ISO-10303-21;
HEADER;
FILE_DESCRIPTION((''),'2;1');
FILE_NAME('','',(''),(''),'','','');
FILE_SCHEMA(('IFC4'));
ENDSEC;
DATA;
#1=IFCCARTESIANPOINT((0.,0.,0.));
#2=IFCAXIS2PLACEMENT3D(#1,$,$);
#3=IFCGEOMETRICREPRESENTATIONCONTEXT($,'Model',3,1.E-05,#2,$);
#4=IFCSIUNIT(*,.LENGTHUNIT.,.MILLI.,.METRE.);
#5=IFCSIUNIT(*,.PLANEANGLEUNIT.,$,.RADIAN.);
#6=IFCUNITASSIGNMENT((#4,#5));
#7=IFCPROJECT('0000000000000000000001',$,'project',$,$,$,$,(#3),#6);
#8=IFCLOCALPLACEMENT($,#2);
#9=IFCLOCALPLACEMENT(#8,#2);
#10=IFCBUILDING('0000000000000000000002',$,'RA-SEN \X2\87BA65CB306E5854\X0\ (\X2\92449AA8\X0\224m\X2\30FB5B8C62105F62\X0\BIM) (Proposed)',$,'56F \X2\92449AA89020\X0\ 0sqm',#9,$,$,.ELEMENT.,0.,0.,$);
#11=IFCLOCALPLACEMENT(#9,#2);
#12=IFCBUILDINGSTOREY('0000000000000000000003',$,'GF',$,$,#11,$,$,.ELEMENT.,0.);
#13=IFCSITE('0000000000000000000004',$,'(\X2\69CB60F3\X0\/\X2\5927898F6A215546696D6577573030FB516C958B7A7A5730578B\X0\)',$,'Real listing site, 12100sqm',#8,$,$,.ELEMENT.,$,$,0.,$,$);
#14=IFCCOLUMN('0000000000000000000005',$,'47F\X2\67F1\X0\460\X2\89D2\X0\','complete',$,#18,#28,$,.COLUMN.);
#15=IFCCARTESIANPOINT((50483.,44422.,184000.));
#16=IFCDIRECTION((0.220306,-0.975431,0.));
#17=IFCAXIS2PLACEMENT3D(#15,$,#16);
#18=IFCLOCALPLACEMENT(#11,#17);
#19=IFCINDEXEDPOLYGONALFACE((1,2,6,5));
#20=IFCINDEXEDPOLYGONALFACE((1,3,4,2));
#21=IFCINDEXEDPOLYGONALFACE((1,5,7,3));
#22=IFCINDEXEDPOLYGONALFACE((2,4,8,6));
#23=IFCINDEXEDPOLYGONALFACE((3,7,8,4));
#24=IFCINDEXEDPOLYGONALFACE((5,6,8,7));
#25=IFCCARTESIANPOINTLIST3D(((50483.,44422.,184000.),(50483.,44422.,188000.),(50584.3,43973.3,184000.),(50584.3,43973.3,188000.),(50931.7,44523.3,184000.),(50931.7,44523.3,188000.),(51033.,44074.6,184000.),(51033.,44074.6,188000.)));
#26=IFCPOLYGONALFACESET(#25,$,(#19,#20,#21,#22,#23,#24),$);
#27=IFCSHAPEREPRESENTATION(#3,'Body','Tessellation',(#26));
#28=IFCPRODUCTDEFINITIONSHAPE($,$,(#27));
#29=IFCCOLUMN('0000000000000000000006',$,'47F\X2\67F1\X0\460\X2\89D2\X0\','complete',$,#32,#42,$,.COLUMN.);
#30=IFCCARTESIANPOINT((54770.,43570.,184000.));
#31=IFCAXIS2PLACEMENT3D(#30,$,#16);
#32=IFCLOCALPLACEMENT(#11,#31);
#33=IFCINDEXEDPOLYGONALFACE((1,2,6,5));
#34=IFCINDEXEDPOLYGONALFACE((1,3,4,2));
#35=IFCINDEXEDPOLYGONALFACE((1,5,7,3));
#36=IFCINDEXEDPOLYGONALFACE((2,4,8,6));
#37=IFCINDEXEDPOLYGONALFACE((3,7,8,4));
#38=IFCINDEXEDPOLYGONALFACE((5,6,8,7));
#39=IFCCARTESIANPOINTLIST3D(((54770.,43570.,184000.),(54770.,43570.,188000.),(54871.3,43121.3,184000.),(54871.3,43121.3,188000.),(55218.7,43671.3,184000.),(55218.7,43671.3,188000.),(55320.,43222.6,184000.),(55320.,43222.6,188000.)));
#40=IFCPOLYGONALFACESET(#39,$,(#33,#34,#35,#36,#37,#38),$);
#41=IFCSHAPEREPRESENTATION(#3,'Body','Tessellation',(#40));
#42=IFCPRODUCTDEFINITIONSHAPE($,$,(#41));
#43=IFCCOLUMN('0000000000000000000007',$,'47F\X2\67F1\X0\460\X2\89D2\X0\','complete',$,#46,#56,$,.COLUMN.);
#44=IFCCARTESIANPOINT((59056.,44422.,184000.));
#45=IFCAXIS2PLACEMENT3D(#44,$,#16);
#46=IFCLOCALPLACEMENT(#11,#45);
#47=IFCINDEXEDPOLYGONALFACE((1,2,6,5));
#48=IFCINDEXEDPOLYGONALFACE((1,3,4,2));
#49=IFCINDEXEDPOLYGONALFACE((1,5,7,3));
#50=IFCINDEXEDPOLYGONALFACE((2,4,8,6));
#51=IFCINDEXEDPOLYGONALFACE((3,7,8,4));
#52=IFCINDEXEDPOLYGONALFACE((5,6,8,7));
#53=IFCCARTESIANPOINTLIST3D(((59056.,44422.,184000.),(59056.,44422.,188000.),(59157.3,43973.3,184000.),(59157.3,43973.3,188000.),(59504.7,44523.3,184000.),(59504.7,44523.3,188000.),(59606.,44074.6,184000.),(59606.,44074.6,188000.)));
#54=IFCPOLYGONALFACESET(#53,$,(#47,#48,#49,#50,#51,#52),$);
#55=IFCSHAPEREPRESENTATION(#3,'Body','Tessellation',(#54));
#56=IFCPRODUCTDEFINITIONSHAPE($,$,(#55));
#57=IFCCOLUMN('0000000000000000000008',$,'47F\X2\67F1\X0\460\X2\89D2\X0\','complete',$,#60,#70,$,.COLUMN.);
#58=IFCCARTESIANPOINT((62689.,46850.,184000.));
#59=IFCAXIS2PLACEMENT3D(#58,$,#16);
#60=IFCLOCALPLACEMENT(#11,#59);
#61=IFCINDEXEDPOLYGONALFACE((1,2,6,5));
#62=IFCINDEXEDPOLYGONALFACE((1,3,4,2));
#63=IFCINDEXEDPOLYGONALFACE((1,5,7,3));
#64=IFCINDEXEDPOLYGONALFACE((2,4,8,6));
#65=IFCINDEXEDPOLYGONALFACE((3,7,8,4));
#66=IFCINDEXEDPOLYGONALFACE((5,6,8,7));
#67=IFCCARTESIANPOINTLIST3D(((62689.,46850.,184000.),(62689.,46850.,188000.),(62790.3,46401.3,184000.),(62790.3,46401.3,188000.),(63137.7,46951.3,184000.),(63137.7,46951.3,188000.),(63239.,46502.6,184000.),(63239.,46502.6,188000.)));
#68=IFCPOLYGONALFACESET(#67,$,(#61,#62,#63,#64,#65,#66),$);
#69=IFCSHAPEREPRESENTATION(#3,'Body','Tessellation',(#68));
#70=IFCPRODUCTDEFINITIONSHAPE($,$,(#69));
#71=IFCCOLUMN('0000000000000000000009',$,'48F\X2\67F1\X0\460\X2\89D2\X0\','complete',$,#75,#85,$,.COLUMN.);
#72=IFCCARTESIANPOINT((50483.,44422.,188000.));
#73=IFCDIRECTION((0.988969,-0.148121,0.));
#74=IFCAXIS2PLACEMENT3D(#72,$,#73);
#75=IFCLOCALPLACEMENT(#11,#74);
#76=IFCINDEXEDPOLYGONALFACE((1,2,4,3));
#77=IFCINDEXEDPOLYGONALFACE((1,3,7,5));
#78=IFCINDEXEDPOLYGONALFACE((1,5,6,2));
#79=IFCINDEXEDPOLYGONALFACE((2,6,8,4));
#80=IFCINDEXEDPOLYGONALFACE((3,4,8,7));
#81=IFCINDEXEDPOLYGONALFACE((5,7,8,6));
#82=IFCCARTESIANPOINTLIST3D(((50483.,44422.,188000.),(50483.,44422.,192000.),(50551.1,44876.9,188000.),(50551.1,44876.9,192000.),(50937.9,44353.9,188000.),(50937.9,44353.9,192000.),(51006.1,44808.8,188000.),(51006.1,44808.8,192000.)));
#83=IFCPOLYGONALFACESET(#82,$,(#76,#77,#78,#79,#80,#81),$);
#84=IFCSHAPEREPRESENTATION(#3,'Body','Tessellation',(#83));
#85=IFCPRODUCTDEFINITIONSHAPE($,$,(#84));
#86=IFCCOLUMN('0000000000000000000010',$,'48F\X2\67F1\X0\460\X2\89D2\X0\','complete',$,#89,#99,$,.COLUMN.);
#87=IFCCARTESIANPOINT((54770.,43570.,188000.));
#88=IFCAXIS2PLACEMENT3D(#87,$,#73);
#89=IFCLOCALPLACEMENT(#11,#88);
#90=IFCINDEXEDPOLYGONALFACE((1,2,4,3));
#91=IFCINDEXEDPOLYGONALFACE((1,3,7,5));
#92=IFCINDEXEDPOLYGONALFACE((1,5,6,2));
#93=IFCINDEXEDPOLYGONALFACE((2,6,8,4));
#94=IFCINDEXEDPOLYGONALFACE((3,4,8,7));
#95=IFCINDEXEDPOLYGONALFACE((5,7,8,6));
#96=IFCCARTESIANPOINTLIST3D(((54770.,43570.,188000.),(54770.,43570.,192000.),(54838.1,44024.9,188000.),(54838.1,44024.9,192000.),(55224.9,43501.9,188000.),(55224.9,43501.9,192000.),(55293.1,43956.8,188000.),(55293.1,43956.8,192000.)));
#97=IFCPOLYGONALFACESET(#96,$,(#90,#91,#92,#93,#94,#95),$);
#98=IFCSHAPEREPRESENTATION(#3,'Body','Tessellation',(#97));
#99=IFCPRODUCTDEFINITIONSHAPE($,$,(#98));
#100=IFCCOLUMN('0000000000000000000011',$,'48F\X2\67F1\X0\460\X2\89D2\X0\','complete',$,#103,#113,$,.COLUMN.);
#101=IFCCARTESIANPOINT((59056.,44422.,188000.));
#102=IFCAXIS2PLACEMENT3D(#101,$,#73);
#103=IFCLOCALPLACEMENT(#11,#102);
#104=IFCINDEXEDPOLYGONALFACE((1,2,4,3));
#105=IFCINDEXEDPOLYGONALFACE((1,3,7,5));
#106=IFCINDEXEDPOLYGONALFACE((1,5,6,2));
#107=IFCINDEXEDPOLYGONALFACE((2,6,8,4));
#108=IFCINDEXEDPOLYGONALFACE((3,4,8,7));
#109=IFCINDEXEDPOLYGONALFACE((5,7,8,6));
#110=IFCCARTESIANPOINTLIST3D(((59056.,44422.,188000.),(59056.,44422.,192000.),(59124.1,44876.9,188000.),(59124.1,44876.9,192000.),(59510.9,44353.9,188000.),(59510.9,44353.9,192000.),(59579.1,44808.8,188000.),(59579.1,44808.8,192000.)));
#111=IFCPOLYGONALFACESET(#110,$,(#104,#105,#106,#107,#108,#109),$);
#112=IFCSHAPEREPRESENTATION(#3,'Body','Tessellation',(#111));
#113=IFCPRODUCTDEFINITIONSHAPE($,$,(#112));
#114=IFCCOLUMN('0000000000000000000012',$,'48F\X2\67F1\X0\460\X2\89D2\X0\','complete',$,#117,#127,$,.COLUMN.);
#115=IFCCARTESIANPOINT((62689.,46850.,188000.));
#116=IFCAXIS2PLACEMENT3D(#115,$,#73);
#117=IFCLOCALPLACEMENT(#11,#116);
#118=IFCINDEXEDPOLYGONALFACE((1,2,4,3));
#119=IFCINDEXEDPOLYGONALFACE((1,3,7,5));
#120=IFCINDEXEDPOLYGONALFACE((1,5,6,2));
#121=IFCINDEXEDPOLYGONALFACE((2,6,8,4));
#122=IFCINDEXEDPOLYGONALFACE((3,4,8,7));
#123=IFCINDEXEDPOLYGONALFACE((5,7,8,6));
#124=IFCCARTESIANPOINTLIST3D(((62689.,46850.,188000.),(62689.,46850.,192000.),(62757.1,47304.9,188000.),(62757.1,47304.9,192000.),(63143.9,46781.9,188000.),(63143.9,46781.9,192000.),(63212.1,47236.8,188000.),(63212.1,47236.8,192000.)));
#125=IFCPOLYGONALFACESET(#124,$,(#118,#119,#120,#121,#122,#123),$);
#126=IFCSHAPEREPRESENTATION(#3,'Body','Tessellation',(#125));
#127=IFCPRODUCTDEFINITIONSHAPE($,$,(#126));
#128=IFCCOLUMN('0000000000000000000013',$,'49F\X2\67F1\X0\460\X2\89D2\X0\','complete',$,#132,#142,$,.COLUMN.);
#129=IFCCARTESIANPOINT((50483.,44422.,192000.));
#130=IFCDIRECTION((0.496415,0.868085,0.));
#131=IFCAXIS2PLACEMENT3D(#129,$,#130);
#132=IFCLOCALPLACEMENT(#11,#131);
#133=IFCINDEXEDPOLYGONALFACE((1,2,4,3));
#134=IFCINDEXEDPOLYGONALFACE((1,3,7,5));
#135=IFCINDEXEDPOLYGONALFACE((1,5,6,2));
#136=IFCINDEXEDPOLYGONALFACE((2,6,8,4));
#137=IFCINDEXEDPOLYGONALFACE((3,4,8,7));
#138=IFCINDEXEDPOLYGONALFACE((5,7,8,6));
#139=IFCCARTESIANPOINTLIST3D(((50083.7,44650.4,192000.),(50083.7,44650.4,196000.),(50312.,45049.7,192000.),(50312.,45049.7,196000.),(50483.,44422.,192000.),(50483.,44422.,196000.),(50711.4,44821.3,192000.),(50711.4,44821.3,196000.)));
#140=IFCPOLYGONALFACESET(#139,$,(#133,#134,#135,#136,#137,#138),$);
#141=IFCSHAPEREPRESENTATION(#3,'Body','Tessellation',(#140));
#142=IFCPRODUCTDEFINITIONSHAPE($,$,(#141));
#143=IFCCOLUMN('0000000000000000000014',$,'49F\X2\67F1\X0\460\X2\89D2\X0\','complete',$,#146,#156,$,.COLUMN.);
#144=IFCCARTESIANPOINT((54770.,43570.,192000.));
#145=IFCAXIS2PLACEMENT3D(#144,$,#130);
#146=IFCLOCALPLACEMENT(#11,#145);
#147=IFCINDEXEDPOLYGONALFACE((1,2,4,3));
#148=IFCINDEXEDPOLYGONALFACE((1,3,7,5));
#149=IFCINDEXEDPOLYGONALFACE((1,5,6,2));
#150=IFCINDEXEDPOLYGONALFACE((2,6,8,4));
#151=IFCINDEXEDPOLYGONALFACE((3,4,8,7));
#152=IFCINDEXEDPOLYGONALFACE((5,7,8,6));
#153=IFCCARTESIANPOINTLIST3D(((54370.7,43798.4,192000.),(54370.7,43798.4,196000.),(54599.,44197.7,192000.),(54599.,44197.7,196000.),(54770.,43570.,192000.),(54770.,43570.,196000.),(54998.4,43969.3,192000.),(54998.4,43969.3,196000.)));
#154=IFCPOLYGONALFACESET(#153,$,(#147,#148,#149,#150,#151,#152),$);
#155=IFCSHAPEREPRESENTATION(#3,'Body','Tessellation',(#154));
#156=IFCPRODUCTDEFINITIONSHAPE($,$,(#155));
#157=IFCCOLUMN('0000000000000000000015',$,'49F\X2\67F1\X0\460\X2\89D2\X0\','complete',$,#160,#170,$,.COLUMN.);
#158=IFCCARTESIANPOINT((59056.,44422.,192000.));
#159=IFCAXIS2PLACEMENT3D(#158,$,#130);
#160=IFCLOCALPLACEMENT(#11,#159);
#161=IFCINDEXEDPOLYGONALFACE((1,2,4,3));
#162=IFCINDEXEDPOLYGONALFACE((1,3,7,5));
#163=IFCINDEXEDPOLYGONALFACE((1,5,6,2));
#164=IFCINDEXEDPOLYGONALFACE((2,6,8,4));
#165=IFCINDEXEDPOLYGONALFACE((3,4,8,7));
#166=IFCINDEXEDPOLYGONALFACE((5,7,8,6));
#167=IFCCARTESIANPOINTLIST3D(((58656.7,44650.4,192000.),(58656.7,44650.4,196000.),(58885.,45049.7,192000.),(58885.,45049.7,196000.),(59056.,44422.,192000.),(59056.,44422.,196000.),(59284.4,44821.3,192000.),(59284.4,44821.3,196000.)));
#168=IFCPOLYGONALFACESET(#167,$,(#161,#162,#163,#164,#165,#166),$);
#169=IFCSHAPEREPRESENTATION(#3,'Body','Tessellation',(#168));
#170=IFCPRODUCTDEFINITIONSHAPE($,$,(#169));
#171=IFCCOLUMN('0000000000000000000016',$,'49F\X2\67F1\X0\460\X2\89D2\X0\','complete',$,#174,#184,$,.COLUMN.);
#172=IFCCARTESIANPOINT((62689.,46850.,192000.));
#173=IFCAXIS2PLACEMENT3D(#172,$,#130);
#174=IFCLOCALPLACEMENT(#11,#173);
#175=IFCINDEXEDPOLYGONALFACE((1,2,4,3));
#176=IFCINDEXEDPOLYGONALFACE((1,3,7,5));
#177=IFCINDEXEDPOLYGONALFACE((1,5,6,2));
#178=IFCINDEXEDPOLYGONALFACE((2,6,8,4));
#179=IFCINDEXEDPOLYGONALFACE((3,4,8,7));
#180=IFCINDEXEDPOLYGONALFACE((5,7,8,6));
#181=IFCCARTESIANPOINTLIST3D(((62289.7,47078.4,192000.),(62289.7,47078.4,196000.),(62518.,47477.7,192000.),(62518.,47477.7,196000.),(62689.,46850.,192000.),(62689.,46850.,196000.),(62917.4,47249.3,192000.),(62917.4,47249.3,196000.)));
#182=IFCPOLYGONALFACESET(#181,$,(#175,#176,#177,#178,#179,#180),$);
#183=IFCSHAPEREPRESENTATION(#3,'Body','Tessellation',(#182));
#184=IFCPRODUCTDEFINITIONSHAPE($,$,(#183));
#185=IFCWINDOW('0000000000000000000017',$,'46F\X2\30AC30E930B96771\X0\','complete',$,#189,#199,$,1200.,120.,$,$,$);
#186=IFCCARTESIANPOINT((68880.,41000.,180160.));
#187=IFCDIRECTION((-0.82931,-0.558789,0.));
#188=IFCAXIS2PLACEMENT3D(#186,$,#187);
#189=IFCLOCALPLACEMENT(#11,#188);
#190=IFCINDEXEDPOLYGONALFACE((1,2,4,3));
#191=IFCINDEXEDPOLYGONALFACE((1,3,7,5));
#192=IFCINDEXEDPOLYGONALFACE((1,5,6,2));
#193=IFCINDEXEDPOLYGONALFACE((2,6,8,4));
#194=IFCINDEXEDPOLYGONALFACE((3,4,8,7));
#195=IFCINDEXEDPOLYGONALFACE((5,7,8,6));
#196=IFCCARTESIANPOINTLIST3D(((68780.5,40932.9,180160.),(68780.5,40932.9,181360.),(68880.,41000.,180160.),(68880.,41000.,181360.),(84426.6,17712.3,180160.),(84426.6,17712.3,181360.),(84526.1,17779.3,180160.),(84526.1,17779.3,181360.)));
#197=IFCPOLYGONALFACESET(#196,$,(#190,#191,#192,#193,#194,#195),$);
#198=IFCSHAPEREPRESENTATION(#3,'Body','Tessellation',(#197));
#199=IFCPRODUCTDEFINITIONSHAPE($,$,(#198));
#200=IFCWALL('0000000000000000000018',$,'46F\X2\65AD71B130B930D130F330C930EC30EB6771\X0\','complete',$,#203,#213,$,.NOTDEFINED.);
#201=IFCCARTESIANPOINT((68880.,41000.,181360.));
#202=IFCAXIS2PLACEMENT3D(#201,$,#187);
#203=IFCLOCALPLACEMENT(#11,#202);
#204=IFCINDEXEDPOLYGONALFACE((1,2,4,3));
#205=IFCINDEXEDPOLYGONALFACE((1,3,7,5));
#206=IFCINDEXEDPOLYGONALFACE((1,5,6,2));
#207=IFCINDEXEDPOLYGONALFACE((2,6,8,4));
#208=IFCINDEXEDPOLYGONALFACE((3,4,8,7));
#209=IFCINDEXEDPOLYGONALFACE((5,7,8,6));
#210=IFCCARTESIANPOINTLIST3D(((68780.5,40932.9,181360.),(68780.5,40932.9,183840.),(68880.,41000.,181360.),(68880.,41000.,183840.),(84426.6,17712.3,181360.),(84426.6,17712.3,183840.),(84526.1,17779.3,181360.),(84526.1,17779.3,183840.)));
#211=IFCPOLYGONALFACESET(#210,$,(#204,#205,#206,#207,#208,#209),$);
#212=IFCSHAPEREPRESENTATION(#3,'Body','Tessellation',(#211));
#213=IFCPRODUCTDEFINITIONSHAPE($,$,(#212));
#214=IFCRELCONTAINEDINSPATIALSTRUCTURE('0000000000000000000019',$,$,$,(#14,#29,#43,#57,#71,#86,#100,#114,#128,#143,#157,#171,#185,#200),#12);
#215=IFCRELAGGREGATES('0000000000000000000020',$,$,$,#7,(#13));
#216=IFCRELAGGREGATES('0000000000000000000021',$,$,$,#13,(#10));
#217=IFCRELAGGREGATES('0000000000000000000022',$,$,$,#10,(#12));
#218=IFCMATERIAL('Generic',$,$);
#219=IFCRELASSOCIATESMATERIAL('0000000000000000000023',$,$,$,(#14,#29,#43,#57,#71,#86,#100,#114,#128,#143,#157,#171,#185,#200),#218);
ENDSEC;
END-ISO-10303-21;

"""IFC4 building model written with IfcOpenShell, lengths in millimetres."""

from ifc_helpers import new_model, si_unit, frame, frame_2d, origin, place, context, project, spatial, rectangle, extrude, material, element, save


model = new_model("IFC4")

# Units and contexts
model_context = context("Model", 3, precision=1e-05, world=origin())
ifc_project = project(units=[si_unit("LENGTHUNIT", "METRE", prefix="MILLI"), si_unit("PLANEANGLEUNIT", "RADIAN")], contexts=[model_context])

# Site, building, storey
site_placement = place(None, origin())
site = spatial("IfcSite", under=ifc_project, at=site_placement, Name="(構想/大規模商業敷地・公開空地型)", ObjectType="Real listing site, 12100sqm", CompositionType="ELEMENT", RefElevation=0.0)
building_placement = place(site_placement, origin())
building = spatial("IfcBuilding", under=site, at=building_placement, Name="RA-SEN 螺旋の塔 (鉄骨224m・完成形BIM) (Proposed)", ObjectType="56F 鉄骨造 0sqm", CompositionType="ELEMENT", ElevationOfRefHeight=0.0, ElevationOfTerrain=0.0)
storey_placement = place(building_placement, origin())
storey = spatial("IfcBuildingStorey", under=building, at=storey_placement, Name="GF", CompositionType="ELEMENT", Elevation=0.0)

# Columns
ifc_material = material(Name="Generic")
column_1_placement = place(storey_placement, frame((50483.0, 44422.0, 184000.0), x_axis=(0.220306, -0.975431, 0.0)))
element("IfcColumn", 1, at=column_1_placement, inside=storey, material=ifc_material, Name="47F柱460角", Description="complete", PredefinedType="COLUMN", context=model_context, shape_type="SweptSolid", body=[
    extrude(rectangle(XDim=460.0, YDim=460.0, at=frame_2d((230.0, 230.0))), frame((50483.0, 44422.0, 184000.0), x_axis=(0.220306, -0.975431, 0.0)), (0.0, 0.0, 1.0), 4000.0),
])
column_2_placement = place(storey_placement, frame((54770.0, 43570.0, 184000.0), x_axis=(0.220306, -0.975431, 0.0)))
element("IfcColumn", 2, at=column_2_placement, inside=storey, material=ifc_material, Name="47F柱460角", Description="complete", PredefinedType="COLUMN", context=model_context, shape_type="SweptSolid", body=[
    extrude(rectangle(XDim=460.0, YDim=460.0, at=frame_2d((230.0, 230.0))), frame((54770.0, 43570.0, 184000.0), x_axis=(0.220306, -0.975431, 0.0)), (0.0, 0.0, 1.0), 4000.0),
])
column_3_placement = place(storey_placement, frame((59056.0, 44422.0, 184000.0), x_axis=(0.220306, -0.975431, 0.0)))
element("IfcColumn", 3, at=column_3_placement, inside=storey, material=ifc_material, Name="47F柱460角", Description="complete", PredefinedType="COLUMN", context=model_context, shape_type="SweptSolid", body=[
    extrude(rectangle(XDim=460.0, YDim=460.0, at=frame_2d((230.0, 230.0))), frame((59056.0, 44422.0, 184000.0), x_axis=(0.220306, -0.975431, 0.0)), (0.0, 0.0, 1.0), 4000.0),
])
column_4_placement = place(storey_placement, frame((62689.0, 46850.0, 184000.0), x_axis=(0.220306, -0.975431, 0.0)))
element("IfcColumn", 4, at=column_4_placement, inside=storey, material=ifc_material, Name="47F柱460角", Description="complete", PredefinedType="COLUMN", context=model_context, shape_type="SweptSolid", body=[
    extrude(rectangle(XDim=460.0, YDim=460.0, at=frame_2d((230.0, 230.0))), frame((62689.0, 46850.0, 184000.0), x_axis=(0.220306, -0.975431, 0.0)), (0.0, 0.0, 1.0), 4000.0),
])
column_5_placement = place(storey_placement, frame((50483.0, 44422.0, 188000.0), x_axis=(0.988969, -0.148121, 0.0)))
element("IfcColumn", 5, at=column_5_placement, inside=storey, material=ifc_material, Name="48F柱460角", Description="complete", PredefinedType="COLUMN", context=model_context, shape_type="SweptSolid", body=[
    extrude(rectangle(XDim=460.0, YDim=460.0, at=frame_2d((230.0, 230.0))), frame((50483.0, 44422.0, 188000.0), x_axis=(0.988969, -0.148121, 0.0)), (0.0, 0.0, 1.0), 4000.0),
])
column_6_placement = place(storey_placement, frame((54770.0, 43570.0, 188000.0), x_axis=(0.988969, -0.148121, 0.0)))
element("IfcColumn", 6, at=column_6_placement, inside=storey, material=ifc_material, Name="48F柱460角", Description="complete", PredefinedType="COLUMN", context=model_context, shape_type="SweptSolid", body=[
    extrude(rectangle(XDim=460.0, YDim=460.0, at=frame_2d((230.0, 230.0))), frame((54770.0, 43570.0, 188000.0), x_axis=(0.988969, -0.148121, 0.0)), (0.0, 0.0, 1.0), 4000.0),
])
column_7_placement = place(storey_placement, frame((59056.0, 44422.0, 188000.0), x_axis=(0.988969, -0.148121, 0.0)))
element("IfcColumn", 7, at=column_7_placement, inside=storey, material=ifc_material, Name="48F柱460角", Description="complete", PredefinedType="COLUMN", context=model_context, shape_type="SweptSolid", body=[
    extrude(rectangle(XDim=460.0, YDim=460.0, at=frame_2d((230.0, 230.0))), frame((59056.0, 44422.0, 188000.0), x_axis=(0.988969, -0.148121, 0.0)), (0.0, 0.0, 1.0), 4000.0),
])
column_8_placement = place(storey_placement, frame((62689.0, 46850.0, 188000.0), x_axis=(0.988969, -0.148121, 0.0)))
element("IfcColumn", 8, at=column_8_placement, inside=storey, material=ifc_material, Name="48F柱460角", Description="complete", PredefinedType="COLUMN", context=model_context, shape_type="SweptSolid", body=[
    extrude(rectangle(XDim=460.0, YDim=460.0, at=frame_2d((230.0, 230.0))), frame((62689.0, 46850.0, 188000.0), x_axis=(0.988969, -0.148121, 0.0)), (0.0, 0.0, 1.0), 4000.0),
])
column_9_placement = place(storey_placement, frame((50483.0, 44422.0, 192000.0), x_axis=(0.496415, 0.868085, 0.0)))
element("IfcColumn", 9, at=column_9_placement, inside=storey, material=ifc_material, Name="49F柱460角", Description="complete", PredefinedType="COLUMN", context=model_context, shape_type="SweptSolid", body=[
    extrude(rectangle(XDim=460.0, YDim=460.0, at=frame_2d((230.0, 230.0))), frame((50483.0, 44422.0, 192000.0), x_axis=(0.496415, 0.868085, 0.0)), (0.0, 0.0, 1.0), 4000.0),
])
column_10_placement = place(storey_placement, frame((54770.0, 43570.0, 192000.0), x_axis=(0.496415, 0.868085, 0.0)))
element("IfcColumn", 10, at=column_10_placement, inside=storey, material=ifc_material, Name="49F柱460角", Description="complete", PredefinedType="COLUMN", context=model_context, shape_type="SweptSolid", body=[
    extrude(rectangle(XDim=460.0, YDim=460.0, at=frame_2d((230.0, 230.0))), frame((54770.0, 43570.0, 192000.0), x_axis=(0.496415, 0.868085, 0.0)), (0.0, 0.0, 1.0), 4000.0),
])
column_11_placement = place(storey_placement, frame((59056.0, 44422.0, 192000.0), x_axis=(0.496415, 0.868085, 0.0)))
element("IfcColumn", 11, at=column_11_placement, inside=storey, material=ifc_material, Name="49F柱460角", Description="complete", PredefinedType="COLUMN", context=model_context, shape_type="SweptSolid", body=[
    extrude(rectangle(XDim=460.0, YDim=460.0, at=frame_2d((230.0, 230.0))), frame((59056.0, 44422.0, 192000.0), x_axis=(0.496415, 0.868085, 0.0)), (0.0, 0.0, 1.0), 4000.0),
])
column_12_placement = place(storey_placement, frame((62689.0, 46850.0, 192000.0), x_axis=(0.496415, 0.868085, 0.0)))
element("IfcColumn", 12, at=column_12_placement, inside=storey, material=ifc_material, Name="49F柱460角", Description="complete", PredefinedType="COLUMN", context=model_context, shape_type="SweptSolid", body=[
    extrude(rectangle(XDim=460.0, YDim=460.0, at=frame_2d((230.0, 230.0))), frame((62689.0, 46850.0, 192000.0), x_axis=(0.496415, 0.868085, 0.0)), (0.0, 0.0, 1.0), 4000.0),
])

# Window
window_1_placement = place(storey_placement, frame((68880.0, 41000.0, 180160.0), x_axis=(-0.82931, -0.558789, 0.0)))
element("IfcWindow", 13, at=window_1_placement, inside=storey, material=ifc_material, Name="46Fガラス東", Description="complete", OverallHeight=1200.0, OverallWidth=120.0, context=model_context, shape_type="SweptSolid", body=[
    extrude(rectangle(XDim=120.0, YDim=28000.0, at=frame_2d((60.0, 14000.0))), frame((68880.0, 41000.0, 180160.0), x_axis=(-0.82931, -0.558789, 0.0)), (0.0, 0.0, 1.0), 1200.0),
])

# Wall
wall_1_placement = place(storey_placement, frame((68880.0, 41000.0, 181360.0), x_axis=(-0.82931, -0.558789, 0.0)))
element("IfcWall", 14, at=wall_1_placement, inside=storey, material=ifc_material, Name="46F断熱スパンドレル東", Description="complete", PredefinedType="NOTDEFINED", context=model_context, shape_type="SweptSolid", body=[
    extrude(rectangle(XDim=120.0, YDim=28000.0, at=frame_2d((60.0, 14000.0))), frame((68880.0, 41000.0, 181360.0), x_axis=(-0.82931, -0.558789, 0.0)), (0.0, 0.0, 1.0), 2480.0),
])

save(model, "model.ifc")
